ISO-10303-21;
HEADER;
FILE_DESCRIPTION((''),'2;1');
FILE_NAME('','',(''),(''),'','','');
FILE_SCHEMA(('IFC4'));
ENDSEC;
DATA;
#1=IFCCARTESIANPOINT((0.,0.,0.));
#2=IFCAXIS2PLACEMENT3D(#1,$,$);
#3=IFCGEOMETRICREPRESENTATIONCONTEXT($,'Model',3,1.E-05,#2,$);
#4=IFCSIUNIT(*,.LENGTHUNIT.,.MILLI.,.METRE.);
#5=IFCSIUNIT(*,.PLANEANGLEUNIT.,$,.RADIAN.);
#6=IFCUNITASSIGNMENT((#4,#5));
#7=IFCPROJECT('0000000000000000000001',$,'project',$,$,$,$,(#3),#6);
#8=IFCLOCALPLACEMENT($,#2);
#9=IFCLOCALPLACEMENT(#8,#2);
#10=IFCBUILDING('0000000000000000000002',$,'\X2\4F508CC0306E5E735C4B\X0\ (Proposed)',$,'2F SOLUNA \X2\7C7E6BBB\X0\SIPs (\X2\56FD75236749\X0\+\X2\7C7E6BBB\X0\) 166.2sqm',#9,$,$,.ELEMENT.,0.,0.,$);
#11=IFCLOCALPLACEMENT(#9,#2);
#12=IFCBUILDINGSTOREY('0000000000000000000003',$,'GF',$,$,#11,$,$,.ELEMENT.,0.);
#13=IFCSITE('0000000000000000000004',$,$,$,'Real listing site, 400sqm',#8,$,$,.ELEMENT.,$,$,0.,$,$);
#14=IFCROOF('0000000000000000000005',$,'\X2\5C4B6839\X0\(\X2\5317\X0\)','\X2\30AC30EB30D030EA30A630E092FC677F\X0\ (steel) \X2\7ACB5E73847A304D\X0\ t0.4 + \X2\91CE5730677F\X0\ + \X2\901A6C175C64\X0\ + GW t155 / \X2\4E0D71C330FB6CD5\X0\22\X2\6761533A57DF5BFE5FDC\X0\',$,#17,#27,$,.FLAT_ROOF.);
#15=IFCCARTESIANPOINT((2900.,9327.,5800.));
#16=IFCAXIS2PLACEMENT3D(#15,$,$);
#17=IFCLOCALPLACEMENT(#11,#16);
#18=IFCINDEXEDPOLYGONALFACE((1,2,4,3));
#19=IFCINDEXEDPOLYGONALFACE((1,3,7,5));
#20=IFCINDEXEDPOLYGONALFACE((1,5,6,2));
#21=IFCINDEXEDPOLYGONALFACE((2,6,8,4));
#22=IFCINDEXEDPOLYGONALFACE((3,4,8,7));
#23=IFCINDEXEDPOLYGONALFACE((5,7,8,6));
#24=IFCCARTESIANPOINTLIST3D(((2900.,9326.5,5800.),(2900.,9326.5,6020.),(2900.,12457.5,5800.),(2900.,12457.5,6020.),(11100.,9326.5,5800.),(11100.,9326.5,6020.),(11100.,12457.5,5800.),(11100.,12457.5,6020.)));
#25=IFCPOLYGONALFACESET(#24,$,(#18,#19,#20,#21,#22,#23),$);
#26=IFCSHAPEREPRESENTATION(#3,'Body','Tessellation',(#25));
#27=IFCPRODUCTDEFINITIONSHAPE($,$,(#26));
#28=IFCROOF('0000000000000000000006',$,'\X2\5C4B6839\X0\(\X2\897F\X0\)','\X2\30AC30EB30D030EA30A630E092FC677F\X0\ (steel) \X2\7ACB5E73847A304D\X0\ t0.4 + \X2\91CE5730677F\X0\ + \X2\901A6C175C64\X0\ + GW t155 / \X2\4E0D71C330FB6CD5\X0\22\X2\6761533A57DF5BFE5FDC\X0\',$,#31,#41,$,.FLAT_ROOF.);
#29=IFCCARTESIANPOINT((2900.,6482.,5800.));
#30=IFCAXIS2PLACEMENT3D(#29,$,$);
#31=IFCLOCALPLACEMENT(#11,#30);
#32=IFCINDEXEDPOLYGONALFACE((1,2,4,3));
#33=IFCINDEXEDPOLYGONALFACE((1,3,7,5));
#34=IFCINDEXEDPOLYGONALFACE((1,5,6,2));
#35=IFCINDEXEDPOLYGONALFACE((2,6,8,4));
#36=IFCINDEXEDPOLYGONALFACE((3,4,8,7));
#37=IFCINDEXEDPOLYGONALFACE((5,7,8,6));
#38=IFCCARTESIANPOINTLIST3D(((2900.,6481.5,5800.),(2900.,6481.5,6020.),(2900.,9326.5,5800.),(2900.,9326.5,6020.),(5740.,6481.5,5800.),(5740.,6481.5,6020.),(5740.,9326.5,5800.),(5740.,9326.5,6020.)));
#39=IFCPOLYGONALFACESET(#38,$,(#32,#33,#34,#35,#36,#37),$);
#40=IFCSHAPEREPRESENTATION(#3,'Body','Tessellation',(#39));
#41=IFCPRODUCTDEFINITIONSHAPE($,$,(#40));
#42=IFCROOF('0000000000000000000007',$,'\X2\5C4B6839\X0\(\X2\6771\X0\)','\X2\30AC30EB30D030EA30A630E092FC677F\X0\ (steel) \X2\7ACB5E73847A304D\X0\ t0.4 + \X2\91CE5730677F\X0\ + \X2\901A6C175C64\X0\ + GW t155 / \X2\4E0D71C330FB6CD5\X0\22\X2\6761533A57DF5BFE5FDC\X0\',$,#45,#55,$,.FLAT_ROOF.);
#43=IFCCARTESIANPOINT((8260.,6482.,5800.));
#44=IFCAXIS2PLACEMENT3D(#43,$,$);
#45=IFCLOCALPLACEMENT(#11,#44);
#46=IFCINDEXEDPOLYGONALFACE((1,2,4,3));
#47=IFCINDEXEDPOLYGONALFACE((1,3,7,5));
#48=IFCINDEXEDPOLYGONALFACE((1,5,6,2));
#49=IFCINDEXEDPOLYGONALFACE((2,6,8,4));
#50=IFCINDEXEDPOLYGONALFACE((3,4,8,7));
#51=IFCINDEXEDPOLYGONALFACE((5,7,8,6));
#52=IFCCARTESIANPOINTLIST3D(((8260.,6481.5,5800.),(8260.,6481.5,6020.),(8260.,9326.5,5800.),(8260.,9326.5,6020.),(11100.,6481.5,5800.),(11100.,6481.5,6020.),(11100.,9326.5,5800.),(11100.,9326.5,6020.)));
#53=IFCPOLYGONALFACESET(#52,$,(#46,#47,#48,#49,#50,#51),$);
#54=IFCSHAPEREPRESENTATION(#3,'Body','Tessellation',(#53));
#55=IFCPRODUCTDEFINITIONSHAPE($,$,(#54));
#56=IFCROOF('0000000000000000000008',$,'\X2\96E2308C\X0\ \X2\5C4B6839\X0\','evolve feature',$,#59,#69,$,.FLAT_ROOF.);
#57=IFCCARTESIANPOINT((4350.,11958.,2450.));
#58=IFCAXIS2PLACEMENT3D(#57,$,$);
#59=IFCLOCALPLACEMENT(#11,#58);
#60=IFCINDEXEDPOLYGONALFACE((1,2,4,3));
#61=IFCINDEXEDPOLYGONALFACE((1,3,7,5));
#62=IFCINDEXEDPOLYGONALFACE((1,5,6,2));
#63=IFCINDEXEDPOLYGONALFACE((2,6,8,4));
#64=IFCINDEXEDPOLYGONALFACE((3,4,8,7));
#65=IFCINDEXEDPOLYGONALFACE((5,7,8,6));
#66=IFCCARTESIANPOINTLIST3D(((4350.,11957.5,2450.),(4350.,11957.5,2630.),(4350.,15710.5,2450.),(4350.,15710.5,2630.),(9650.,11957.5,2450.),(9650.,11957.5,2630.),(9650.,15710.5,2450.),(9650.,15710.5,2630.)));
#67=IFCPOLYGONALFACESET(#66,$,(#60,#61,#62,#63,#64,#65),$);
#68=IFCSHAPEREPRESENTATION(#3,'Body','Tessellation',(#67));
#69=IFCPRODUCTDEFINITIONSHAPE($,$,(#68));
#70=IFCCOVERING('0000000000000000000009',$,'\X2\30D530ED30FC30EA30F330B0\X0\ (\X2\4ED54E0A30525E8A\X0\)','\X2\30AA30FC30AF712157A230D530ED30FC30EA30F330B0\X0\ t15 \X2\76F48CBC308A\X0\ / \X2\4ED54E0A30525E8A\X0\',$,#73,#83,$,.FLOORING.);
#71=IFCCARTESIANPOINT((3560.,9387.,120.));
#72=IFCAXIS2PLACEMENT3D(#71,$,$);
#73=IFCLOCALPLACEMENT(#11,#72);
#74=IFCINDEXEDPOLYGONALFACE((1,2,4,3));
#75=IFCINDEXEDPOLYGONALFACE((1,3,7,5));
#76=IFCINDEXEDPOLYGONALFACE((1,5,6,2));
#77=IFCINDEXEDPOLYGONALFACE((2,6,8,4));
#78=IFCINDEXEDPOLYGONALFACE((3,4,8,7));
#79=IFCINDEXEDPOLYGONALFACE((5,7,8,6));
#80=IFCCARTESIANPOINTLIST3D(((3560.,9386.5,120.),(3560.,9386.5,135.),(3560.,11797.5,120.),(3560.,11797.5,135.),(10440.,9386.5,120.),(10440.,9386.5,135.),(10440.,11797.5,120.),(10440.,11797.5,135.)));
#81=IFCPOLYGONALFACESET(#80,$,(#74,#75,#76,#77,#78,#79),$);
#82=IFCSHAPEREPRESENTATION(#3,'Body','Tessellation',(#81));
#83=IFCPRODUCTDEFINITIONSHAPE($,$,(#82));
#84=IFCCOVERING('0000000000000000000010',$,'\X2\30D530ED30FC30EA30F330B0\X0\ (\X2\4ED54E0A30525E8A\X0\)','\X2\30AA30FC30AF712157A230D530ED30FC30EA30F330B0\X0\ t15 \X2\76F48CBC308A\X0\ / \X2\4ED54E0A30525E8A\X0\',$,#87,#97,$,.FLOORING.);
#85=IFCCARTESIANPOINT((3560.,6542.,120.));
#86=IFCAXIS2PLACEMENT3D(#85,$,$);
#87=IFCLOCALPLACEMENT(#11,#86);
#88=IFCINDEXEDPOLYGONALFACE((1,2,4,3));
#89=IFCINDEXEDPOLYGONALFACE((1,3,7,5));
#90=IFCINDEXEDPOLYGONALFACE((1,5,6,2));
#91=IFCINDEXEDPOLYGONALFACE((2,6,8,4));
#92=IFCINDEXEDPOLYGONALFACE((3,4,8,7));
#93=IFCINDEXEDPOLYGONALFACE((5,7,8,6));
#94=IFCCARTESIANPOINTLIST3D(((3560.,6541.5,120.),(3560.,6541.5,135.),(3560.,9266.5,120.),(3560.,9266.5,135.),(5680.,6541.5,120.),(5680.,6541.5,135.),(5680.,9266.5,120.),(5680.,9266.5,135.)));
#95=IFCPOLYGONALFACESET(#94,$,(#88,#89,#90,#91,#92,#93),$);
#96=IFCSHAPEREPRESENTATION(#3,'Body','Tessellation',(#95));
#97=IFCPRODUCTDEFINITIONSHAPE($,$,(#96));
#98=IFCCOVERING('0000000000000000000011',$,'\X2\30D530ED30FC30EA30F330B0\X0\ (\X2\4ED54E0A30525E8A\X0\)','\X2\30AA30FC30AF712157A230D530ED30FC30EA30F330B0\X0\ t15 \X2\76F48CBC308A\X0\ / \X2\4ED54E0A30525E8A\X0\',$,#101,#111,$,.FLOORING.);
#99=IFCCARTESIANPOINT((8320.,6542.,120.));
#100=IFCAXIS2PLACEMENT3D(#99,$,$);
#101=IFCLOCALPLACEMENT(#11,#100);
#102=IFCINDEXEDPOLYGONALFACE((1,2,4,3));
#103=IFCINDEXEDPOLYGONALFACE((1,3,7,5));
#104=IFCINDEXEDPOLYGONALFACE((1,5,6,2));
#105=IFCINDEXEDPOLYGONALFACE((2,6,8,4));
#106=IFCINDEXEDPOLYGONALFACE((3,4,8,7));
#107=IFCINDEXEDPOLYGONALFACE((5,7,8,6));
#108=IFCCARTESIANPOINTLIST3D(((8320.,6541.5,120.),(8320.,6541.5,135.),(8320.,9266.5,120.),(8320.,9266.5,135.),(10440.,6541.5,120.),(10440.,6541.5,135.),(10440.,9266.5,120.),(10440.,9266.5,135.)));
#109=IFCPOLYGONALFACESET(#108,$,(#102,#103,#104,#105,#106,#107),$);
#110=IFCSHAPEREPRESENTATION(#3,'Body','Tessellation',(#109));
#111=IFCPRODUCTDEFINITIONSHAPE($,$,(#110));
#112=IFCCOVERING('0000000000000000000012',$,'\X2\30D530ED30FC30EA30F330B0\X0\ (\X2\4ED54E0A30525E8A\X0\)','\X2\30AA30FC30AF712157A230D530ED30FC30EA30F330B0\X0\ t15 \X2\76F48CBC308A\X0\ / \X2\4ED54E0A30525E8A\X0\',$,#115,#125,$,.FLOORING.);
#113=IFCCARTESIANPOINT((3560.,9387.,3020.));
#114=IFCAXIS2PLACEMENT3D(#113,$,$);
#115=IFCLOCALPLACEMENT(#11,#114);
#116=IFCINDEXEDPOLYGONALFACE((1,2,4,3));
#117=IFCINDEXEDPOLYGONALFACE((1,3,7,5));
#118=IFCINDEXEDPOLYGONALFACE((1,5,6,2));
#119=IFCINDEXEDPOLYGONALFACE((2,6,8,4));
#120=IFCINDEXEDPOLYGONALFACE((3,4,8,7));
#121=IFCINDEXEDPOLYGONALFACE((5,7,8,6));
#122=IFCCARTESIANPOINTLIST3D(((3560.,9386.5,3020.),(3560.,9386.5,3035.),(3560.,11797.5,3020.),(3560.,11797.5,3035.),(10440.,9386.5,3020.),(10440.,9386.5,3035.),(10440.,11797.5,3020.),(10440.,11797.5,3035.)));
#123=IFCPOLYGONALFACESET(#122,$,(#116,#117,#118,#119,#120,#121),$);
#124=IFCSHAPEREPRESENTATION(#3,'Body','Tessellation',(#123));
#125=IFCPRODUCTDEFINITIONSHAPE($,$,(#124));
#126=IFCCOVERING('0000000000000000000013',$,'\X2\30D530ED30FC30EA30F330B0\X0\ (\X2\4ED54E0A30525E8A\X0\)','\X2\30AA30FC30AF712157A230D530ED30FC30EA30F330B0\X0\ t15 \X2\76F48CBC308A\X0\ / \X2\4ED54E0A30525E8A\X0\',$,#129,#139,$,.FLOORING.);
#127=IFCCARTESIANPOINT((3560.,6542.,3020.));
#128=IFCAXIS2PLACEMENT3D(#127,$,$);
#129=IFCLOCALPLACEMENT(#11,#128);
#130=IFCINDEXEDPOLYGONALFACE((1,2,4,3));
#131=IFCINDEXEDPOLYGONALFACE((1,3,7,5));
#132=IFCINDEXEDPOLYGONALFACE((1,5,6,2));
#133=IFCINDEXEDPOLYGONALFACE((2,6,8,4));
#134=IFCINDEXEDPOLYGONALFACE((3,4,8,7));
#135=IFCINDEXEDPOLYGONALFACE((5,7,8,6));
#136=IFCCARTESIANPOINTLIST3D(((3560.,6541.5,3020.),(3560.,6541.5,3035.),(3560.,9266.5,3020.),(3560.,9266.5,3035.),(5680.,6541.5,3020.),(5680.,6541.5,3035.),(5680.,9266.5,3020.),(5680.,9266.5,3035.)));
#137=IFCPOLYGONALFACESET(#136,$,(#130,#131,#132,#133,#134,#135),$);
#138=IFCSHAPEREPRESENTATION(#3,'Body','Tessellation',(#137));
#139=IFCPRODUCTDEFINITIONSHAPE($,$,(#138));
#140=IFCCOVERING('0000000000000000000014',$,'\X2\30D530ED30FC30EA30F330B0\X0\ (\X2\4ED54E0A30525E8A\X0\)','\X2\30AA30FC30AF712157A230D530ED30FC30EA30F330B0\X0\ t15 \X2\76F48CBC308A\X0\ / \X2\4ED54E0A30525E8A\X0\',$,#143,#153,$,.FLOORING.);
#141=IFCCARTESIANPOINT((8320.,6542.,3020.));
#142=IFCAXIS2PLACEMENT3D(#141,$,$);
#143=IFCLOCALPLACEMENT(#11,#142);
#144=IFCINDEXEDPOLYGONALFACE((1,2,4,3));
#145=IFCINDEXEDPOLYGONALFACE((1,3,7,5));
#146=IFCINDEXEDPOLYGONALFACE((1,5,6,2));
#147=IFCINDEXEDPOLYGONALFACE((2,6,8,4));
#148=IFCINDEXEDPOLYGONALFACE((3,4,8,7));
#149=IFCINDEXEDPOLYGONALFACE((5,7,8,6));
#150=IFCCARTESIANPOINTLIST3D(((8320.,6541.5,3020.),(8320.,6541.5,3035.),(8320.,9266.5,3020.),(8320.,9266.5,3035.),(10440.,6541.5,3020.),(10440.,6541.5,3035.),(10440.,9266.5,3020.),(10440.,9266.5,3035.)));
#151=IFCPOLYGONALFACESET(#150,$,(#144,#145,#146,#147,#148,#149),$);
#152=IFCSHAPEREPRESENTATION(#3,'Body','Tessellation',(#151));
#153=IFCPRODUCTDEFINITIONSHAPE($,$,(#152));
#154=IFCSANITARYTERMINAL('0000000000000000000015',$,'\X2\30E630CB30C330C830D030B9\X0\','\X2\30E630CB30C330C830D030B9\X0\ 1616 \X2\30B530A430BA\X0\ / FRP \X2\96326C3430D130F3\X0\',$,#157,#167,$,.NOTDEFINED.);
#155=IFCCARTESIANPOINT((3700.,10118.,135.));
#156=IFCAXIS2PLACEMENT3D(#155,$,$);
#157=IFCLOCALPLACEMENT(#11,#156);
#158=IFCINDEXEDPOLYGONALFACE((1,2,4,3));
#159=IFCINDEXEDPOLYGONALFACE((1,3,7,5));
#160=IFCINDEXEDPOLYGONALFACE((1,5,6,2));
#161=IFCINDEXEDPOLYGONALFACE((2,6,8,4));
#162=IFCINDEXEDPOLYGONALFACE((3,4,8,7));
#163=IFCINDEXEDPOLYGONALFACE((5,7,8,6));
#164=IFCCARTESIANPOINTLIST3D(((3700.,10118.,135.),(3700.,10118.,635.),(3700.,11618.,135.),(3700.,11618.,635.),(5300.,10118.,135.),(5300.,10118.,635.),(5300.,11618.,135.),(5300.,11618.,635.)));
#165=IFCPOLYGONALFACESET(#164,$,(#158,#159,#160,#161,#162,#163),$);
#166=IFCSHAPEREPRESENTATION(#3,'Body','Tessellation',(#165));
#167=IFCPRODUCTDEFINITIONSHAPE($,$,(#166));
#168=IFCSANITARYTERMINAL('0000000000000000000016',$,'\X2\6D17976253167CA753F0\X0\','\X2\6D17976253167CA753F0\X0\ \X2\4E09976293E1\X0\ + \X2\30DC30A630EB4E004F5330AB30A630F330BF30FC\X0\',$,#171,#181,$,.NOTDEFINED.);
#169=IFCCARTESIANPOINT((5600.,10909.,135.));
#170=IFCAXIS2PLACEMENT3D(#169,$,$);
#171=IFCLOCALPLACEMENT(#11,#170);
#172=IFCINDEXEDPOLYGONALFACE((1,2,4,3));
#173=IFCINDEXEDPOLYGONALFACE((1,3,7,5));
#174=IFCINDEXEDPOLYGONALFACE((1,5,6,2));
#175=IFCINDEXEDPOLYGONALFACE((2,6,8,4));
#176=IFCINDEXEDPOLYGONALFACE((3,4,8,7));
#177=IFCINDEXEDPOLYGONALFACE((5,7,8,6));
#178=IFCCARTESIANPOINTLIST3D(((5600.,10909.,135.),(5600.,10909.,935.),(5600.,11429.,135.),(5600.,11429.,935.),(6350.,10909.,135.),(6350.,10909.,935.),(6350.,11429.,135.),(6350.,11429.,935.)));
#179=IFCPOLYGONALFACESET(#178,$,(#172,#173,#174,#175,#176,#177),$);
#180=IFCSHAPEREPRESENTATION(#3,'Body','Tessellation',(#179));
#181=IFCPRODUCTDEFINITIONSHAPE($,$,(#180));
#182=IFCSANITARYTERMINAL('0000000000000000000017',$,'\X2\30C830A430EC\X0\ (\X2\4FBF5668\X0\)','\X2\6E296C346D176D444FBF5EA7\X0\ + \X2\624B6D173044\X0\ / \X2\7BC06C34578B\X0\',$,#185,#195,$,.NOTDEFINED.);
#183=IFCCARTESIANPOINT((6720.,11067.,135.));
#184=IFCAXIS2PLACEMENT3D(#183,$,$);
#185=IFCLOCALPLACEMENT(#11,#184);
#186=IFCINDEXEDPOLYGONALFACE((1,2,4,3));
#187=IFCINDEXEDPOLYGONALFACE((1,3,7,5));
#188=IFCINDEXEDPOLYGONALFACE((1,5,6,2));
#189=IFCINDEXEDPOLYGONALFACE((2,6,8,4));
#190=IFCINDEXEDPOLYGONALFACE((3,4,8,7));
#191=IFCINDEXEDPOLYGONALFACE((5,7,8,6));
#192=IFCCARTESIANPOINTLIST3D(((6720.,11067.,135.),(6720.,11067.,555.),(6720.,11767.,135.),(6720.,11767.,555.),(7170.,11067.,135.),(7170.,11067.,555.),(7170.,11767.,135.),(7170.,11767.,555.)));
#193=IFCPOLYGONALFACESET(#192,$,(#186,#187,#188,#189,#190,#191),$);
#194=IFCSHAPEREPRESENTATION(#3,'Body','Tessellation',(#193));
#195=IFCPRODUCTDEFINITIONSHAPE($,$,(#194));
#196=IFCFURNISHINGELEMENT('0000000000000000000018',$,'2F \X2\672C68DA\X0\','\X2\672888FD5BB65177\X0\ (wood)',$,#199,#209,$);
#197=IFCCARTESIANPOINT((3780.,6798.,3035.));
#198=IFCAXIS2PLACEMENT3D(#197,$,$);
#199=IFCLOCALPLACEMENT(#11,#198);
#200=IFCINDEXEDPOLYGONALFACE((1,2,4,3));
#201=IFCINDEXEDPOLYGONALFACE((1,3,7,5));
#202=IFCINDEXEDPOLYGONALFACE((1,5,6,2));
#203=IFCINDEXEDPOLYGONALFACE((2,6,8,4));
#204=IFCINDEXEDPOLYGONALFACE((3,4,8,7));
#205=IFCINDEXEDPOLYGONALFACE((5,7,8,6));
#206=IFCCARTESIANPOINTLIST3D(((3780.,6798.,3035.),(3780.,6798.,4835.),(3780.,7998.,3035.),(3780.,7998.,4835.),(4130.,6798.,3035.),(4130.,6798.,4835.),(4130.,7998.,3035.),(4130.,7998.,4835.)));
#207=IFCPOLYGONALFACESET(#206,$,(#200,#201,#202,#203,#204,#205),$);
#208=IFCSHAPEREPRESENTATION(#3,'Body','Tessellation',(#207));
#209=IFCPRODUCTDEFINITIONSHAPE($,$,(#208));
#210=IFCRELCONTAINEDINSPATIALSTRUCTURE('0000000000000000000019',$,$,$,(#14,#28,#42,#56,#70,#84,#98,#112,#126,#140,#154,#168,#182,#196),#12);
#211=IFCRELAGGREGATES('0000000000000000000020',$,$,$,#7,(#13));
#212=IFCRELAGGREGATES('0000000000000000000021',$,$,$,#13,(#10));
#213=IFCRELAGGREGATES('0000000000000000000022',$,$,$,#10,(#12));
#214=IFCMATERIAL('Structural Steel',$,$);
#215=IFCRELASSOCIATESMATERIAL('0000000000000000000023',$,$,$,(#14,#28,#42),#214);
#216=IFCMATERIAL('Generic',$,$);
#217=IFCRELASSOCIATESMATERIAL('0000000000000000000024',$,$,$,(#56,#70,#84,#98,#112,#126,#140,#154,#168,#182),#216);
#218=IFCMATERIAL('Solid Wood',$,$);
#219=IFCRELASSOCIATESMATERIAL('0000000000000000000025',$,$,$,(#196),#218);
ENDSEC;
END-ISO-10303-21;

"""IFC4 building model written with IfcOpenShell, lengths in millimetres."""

from ifc_helpers import new_model, si_unit, frame, frame_2d, origin, place, context, project, spatial, rectangle, extrude, material, element, save


model = new_model("IFC4")

# Units and contexts
model_context = context("Model", 3, precision=1e-05, world=origin())
ifc_project = project(units=[si_unit("LENGTHUNIT", "METRE", prefix="MILLI"), si_unit("PLANEANGLEUNIT", "RADIAN")], contexts=[model_context])

# Site, building, storey
site_placement = place(None, origin())
site = spatial("IfcSite", under=ifc_project, at=site_placement, ObjectType="Real listing site, 400sqm", CompositionType="ELEMENT", RefElevation=0.0)
building_placement = place(site_placement, origin())
building = spatial("IfcBuilding", under=site, at=building_placement, Name="佐賀の平屋 (Proposed)", ObjectType="2F SOLUNA 籾殻SIPs (国産杉+籾殻) 166.2sqm", CompositionType="ELEMENT", ElevationOfRefHeight=0.0, ElevationOfTerrain=0.0)
storey_placement = place(building_placement, origin())
storey = spatial("IfcBuildingStorey", under=building, at=storey_placement, Name="GF", CompositionType="ELEMENT", Elevation=0.0)

# Shared definitions
ifc_material_1 = material(Name="Solid Wood")
ifc_material_2 = material(Name="Generic")

# Roofs
ifc_material_3 = material(Name="Structural Steel")
for number, where, name in (
    (1, (2900.0, 9327.0, 5800.0), "屋根(北)"),
):
    element("IfcRoof", number, at=place(storey_placement, frame(where)), inside=storey, material=ifc_material_3, Name=name, Description="ガルバリウム鋼板 (steel) 立平葺き t0.4 + 野地板 + 通気層 + GW t155 / 不燃・法22条区域対応", PredefinedType="FLAT_ROOF", context=model_context, shape_type="SweptSolid", body=[
        extrude(rectangle(XDim=8200.0, YDim=3131.0, at=frame_2d((4100.0, 1565.0))), frame((2900.0, 9327.0, 5800.0)), (0.0, 0.0, 1.0), 220.0),
    ])
roof_1_placement = place(storey_placement, frame((2900.0, 6482.0, 5800.0)))
element("IfcRoof", 2, at=roof_1_placement, inside=storey, material=ifc_material_3, Name="屋根(西)", Description="ガルバリウム鋼板 (steel) 立平葺き t0.4 + 野地板 + 通気層 + GW t155 / 不燃・法22条区域対応", PredefinedType="FLAT_ROOF", context=model_context, shape_type="SweptSolid", body=[
    extrude(rectangle(XDim=2840.0, YDim=2845.0, at=frame_2d((1420.0, 1422.0))), frame((2900.0, 6482.0, 5800.0)), (0.0, 0.0, 1.0), 220.0),
])
roof_2_placement = place(storey_placement, frame((8260.0, 6482.0, 5800.0)))
element("IfcRoof", 3, at=roof_2_placement, inside=storey, material=ifc_material_3, Name="屋根(東)", Description="ガルバリウム鋼板 (steel) 立平葺き t0.4 + 野地板 + 通気層 + GW t155 / 不燃・法22条区域対応", PredefinedType="FLAT_ROOF", context=model_context, shape_type="SweptSolid", body=[
    extrude(rectangle(XDim=2840.0, YDim=2845.0, at=frame_2d((1420.0, 1422.0))), frame((8260.0, 6482.0, 5800.0)), (0.0, 0.0, 1.0), 220.0),
])
roof_3_placement = place(storey_placement, frame((4350.0, 11958.0, 2450.0)))
element("IfcRoof", 4, at=roof_3_placement, inside=storey, material=ifc_material_2, Name="離れ 屋根", Description="evolve feature", PredefinedType="FLAT_ROOF", context=model_context, shape_type="SweptSolid", body=[
    extrude(rectangle(XDim=5300.0, YDim=3753.0, at=frame_2d((2650.0, 1876.0))), frame((4350.0, 11958.0, 2450.0)), (0.0, 0.0, 1.0), 180.0),
])

# Coverings
covering_1_placement = place(storey_placement, frame((3560.0, 9387.0, 120.0)))
element("IfcCovering", 5, at=covering_1_placement, inside=storey, material=ifc_material_2, Name="フローリング (仕上げ床)", Description="オーク無垢フローリング t15 直貼り / 仕上げ床", PredefinedType="FLOORING", context=model_context, shape_type="SweptSolid", body=[
    extrude(rectangle(XDim=6880.0, YDim=2411.0, at=frame_2d((3440.0, 1205.0))), frame((3560.0, 9387.0, 120.0)), (0.0, 0.0, 1.0), 15.0),
])
covering_2_placement = place(storey_placement, frame((3560.0, 6542.0, 120.0)))
element("IfcCovering", 6, at=covering_2_placement, inside=storey, material=ifc_material_2, Name="フローリング (仕上げ床)", Description="オーク無垢フローリング t15 直貼り / 仕上げ床", PredefinedType="FLOORING", context=model_context, shape_type="SweptSolid", body=[
    extrude(rectangle(XDim=2120.0, YDim=2725.0, at=frame_2d((1060.0, 1362.0))), frame((3560.0, 6542.0, 120.0)), (0.0, 0.0, 1.0), 15.0),
])
covering_3_placement = place(storey_placement, frame((8320.0, 6542.0, 120.0)))
element("IfcCovering", 7, at=covering_3_placement, inside=storey, material=ifc_material_2, Name="フローリング (仕上げ床)", Description="オーク無垢フローリング t15 直貼り / 仕上げ床", PredefinedType="FLOORING", context=model_context, shape_type="SweptSolid", body=[
    extrude(rectangle(XDim=2120.0, YDim=2725.0, at=frame_2d((1060.0, 1362.0))), frame((8320.0, 6542.0, 120.0)), (0.0, 0.0, 1.0), 15.0),
])
covering_4_placement = place(storey_placement, frame((3560.0, 9387.0, 3020.0)))
element("IfcCovering", 8, at=covering_4_placement, inside=storey, material=ifc_material_2, Name="フローリング (仕上げ床)", Description="オーク無垢フローリング t15 直貼り / 仕上げ床", PredefinedType="FLOORING", context=model_context, shape_type="SweptSolid", body=[
    extrude(rectangle(XDim=6880.0, YDim=2411.0, at=frame_2d((3440.0, 1205.0))), frame((3560.0, 9387.0, 3020.0)), (0.0, 0.0, 1.0), 15.0),
])
covering_5_placement = place(storey_placement, frame((3560.0, 6542.0, 3020.0)))
element("IfcCovering", 9, at=covering_5_placement, inside=storey, material=ifc_material_2, Name="フローリング (仕上げ床)", Description="オーク無垢フローリング t15 直貼り / 仕上げ床", PredefinedType="FLOORING", context=model_context, shape_type="SweptSolid", body=[
    extrude(rectangle(XDim=2120.0, YDim=2725.0, at=frame_2d((1060.0, 1362.0))), frame((3560.0, 6542.0, 3020.0)), (0.0, 0.0, 1.0), 15.0),
])
covering_6_placement = place(storey_placement, frame((8320.0, 6542.0, 3020.0)))
element("IfcCovering", 10, at=covering_6_placement, inside=storey, material=ifc_material_2, Name="フローリング (仕上げ床)", Description="オーク無垢フローリング t15 直貼り / 仕上げ床", PredefinedType="FLOORING", context=model_context, shape_type="SweptSolid", body=[
    extrude(rectangle(XDim=2120.0, YDim=2725.0, at=frame_2d((1060.0, 1362.0))), frame((8320.0, 6542.0, 3020.0)), (0.0, 0.0, 1.0), 15.0),
])

# Sanitary terminals
sanitary_terminal_1_placement = place(storey_placement, frame((3700.0, 10118.0, 135.0)))
element("IfcSanitaryTerminal", 11, at=sanitary_terminal_1_placement, inside=storey, material=ifc_material_2, Name="ユニットバス", Description="ユニットバス 1616 サイズ / FRP 防水パン", PredefinedType="NOTDEFINED", context=model_context, shape_type="SweptSolid", body=[
    extrude(rectangle(XDim=1600.0, YDim=1500.0, at=frame_2d((800.0, 750.0))), frame((3700.0, 10118.0, 135.0)), (0.0, 0.0, 1.0), 500.0),
])
sanitary_terminal_2_placement = place(storey_placement, frame((5600.0, 10909.0, 135.0)))
element("IfcSanitaryTerminal", 12, at=sanitary_terminal_2_placement, inside=storey, material=ifc_material_2, Name="洗面化粧台", Description="洗面化粧台 三面鏡 + ボウル一体カウンター", PredefinedType="NOTDEFINED", context=model_context, shape_type="SweptSolid", body=[
    extrude(rectangle(XDim=750.0, YDim=520.0, at=frame_2d((375.0, 260.0))), frame((5600.0, 10909.0, 135.0)), (0.0, 0.0, 1.0), 800.0),
])
sanitary_terminal_3_placement = place(storey_placement, frame((6720.0, 11067.0, 135.0)))
element("IfcSanitaryTerminal", 13, at=sanitary_terminal_3_placement, inside=storey, material=ifc_material_2, Name="トイレ (便器)", Description="温水洗浄便座 + 手洗い / 節水型", PredefinedType="NOTDEFINED", context=model_context, shape_type="SweptSolid", body=[
    extrude(rectangle(XDim=450.0, YDim=700.0, at=frame_2d((225.0, 350.0))), frame((6720.0, 11067.0, 135.0)), (0.0, 0.0, 1.0), 420.0),
])

# Furnishing element
furnishing_placement = place(storey_placement, frame((3780.0, 6798.0, 3035.0)))
element("IfcFurnishingElement", 14, at=furnishing_placement, inside=storey, material=ifc_material_1, Name="2F 本棚", Description="木製家具 (wood)", context=model_context, shape_type="SweptSolid", body=[
    extrude(rectangle(XDim=350.0, YDim=1200.0, at=frame_2d((175.0, 600.0))), frame((3780.0, 6798.0, 3035.0)), (0.0, 0.0, 1.0), 1800.0),
])

save(model, "model.ifc")
